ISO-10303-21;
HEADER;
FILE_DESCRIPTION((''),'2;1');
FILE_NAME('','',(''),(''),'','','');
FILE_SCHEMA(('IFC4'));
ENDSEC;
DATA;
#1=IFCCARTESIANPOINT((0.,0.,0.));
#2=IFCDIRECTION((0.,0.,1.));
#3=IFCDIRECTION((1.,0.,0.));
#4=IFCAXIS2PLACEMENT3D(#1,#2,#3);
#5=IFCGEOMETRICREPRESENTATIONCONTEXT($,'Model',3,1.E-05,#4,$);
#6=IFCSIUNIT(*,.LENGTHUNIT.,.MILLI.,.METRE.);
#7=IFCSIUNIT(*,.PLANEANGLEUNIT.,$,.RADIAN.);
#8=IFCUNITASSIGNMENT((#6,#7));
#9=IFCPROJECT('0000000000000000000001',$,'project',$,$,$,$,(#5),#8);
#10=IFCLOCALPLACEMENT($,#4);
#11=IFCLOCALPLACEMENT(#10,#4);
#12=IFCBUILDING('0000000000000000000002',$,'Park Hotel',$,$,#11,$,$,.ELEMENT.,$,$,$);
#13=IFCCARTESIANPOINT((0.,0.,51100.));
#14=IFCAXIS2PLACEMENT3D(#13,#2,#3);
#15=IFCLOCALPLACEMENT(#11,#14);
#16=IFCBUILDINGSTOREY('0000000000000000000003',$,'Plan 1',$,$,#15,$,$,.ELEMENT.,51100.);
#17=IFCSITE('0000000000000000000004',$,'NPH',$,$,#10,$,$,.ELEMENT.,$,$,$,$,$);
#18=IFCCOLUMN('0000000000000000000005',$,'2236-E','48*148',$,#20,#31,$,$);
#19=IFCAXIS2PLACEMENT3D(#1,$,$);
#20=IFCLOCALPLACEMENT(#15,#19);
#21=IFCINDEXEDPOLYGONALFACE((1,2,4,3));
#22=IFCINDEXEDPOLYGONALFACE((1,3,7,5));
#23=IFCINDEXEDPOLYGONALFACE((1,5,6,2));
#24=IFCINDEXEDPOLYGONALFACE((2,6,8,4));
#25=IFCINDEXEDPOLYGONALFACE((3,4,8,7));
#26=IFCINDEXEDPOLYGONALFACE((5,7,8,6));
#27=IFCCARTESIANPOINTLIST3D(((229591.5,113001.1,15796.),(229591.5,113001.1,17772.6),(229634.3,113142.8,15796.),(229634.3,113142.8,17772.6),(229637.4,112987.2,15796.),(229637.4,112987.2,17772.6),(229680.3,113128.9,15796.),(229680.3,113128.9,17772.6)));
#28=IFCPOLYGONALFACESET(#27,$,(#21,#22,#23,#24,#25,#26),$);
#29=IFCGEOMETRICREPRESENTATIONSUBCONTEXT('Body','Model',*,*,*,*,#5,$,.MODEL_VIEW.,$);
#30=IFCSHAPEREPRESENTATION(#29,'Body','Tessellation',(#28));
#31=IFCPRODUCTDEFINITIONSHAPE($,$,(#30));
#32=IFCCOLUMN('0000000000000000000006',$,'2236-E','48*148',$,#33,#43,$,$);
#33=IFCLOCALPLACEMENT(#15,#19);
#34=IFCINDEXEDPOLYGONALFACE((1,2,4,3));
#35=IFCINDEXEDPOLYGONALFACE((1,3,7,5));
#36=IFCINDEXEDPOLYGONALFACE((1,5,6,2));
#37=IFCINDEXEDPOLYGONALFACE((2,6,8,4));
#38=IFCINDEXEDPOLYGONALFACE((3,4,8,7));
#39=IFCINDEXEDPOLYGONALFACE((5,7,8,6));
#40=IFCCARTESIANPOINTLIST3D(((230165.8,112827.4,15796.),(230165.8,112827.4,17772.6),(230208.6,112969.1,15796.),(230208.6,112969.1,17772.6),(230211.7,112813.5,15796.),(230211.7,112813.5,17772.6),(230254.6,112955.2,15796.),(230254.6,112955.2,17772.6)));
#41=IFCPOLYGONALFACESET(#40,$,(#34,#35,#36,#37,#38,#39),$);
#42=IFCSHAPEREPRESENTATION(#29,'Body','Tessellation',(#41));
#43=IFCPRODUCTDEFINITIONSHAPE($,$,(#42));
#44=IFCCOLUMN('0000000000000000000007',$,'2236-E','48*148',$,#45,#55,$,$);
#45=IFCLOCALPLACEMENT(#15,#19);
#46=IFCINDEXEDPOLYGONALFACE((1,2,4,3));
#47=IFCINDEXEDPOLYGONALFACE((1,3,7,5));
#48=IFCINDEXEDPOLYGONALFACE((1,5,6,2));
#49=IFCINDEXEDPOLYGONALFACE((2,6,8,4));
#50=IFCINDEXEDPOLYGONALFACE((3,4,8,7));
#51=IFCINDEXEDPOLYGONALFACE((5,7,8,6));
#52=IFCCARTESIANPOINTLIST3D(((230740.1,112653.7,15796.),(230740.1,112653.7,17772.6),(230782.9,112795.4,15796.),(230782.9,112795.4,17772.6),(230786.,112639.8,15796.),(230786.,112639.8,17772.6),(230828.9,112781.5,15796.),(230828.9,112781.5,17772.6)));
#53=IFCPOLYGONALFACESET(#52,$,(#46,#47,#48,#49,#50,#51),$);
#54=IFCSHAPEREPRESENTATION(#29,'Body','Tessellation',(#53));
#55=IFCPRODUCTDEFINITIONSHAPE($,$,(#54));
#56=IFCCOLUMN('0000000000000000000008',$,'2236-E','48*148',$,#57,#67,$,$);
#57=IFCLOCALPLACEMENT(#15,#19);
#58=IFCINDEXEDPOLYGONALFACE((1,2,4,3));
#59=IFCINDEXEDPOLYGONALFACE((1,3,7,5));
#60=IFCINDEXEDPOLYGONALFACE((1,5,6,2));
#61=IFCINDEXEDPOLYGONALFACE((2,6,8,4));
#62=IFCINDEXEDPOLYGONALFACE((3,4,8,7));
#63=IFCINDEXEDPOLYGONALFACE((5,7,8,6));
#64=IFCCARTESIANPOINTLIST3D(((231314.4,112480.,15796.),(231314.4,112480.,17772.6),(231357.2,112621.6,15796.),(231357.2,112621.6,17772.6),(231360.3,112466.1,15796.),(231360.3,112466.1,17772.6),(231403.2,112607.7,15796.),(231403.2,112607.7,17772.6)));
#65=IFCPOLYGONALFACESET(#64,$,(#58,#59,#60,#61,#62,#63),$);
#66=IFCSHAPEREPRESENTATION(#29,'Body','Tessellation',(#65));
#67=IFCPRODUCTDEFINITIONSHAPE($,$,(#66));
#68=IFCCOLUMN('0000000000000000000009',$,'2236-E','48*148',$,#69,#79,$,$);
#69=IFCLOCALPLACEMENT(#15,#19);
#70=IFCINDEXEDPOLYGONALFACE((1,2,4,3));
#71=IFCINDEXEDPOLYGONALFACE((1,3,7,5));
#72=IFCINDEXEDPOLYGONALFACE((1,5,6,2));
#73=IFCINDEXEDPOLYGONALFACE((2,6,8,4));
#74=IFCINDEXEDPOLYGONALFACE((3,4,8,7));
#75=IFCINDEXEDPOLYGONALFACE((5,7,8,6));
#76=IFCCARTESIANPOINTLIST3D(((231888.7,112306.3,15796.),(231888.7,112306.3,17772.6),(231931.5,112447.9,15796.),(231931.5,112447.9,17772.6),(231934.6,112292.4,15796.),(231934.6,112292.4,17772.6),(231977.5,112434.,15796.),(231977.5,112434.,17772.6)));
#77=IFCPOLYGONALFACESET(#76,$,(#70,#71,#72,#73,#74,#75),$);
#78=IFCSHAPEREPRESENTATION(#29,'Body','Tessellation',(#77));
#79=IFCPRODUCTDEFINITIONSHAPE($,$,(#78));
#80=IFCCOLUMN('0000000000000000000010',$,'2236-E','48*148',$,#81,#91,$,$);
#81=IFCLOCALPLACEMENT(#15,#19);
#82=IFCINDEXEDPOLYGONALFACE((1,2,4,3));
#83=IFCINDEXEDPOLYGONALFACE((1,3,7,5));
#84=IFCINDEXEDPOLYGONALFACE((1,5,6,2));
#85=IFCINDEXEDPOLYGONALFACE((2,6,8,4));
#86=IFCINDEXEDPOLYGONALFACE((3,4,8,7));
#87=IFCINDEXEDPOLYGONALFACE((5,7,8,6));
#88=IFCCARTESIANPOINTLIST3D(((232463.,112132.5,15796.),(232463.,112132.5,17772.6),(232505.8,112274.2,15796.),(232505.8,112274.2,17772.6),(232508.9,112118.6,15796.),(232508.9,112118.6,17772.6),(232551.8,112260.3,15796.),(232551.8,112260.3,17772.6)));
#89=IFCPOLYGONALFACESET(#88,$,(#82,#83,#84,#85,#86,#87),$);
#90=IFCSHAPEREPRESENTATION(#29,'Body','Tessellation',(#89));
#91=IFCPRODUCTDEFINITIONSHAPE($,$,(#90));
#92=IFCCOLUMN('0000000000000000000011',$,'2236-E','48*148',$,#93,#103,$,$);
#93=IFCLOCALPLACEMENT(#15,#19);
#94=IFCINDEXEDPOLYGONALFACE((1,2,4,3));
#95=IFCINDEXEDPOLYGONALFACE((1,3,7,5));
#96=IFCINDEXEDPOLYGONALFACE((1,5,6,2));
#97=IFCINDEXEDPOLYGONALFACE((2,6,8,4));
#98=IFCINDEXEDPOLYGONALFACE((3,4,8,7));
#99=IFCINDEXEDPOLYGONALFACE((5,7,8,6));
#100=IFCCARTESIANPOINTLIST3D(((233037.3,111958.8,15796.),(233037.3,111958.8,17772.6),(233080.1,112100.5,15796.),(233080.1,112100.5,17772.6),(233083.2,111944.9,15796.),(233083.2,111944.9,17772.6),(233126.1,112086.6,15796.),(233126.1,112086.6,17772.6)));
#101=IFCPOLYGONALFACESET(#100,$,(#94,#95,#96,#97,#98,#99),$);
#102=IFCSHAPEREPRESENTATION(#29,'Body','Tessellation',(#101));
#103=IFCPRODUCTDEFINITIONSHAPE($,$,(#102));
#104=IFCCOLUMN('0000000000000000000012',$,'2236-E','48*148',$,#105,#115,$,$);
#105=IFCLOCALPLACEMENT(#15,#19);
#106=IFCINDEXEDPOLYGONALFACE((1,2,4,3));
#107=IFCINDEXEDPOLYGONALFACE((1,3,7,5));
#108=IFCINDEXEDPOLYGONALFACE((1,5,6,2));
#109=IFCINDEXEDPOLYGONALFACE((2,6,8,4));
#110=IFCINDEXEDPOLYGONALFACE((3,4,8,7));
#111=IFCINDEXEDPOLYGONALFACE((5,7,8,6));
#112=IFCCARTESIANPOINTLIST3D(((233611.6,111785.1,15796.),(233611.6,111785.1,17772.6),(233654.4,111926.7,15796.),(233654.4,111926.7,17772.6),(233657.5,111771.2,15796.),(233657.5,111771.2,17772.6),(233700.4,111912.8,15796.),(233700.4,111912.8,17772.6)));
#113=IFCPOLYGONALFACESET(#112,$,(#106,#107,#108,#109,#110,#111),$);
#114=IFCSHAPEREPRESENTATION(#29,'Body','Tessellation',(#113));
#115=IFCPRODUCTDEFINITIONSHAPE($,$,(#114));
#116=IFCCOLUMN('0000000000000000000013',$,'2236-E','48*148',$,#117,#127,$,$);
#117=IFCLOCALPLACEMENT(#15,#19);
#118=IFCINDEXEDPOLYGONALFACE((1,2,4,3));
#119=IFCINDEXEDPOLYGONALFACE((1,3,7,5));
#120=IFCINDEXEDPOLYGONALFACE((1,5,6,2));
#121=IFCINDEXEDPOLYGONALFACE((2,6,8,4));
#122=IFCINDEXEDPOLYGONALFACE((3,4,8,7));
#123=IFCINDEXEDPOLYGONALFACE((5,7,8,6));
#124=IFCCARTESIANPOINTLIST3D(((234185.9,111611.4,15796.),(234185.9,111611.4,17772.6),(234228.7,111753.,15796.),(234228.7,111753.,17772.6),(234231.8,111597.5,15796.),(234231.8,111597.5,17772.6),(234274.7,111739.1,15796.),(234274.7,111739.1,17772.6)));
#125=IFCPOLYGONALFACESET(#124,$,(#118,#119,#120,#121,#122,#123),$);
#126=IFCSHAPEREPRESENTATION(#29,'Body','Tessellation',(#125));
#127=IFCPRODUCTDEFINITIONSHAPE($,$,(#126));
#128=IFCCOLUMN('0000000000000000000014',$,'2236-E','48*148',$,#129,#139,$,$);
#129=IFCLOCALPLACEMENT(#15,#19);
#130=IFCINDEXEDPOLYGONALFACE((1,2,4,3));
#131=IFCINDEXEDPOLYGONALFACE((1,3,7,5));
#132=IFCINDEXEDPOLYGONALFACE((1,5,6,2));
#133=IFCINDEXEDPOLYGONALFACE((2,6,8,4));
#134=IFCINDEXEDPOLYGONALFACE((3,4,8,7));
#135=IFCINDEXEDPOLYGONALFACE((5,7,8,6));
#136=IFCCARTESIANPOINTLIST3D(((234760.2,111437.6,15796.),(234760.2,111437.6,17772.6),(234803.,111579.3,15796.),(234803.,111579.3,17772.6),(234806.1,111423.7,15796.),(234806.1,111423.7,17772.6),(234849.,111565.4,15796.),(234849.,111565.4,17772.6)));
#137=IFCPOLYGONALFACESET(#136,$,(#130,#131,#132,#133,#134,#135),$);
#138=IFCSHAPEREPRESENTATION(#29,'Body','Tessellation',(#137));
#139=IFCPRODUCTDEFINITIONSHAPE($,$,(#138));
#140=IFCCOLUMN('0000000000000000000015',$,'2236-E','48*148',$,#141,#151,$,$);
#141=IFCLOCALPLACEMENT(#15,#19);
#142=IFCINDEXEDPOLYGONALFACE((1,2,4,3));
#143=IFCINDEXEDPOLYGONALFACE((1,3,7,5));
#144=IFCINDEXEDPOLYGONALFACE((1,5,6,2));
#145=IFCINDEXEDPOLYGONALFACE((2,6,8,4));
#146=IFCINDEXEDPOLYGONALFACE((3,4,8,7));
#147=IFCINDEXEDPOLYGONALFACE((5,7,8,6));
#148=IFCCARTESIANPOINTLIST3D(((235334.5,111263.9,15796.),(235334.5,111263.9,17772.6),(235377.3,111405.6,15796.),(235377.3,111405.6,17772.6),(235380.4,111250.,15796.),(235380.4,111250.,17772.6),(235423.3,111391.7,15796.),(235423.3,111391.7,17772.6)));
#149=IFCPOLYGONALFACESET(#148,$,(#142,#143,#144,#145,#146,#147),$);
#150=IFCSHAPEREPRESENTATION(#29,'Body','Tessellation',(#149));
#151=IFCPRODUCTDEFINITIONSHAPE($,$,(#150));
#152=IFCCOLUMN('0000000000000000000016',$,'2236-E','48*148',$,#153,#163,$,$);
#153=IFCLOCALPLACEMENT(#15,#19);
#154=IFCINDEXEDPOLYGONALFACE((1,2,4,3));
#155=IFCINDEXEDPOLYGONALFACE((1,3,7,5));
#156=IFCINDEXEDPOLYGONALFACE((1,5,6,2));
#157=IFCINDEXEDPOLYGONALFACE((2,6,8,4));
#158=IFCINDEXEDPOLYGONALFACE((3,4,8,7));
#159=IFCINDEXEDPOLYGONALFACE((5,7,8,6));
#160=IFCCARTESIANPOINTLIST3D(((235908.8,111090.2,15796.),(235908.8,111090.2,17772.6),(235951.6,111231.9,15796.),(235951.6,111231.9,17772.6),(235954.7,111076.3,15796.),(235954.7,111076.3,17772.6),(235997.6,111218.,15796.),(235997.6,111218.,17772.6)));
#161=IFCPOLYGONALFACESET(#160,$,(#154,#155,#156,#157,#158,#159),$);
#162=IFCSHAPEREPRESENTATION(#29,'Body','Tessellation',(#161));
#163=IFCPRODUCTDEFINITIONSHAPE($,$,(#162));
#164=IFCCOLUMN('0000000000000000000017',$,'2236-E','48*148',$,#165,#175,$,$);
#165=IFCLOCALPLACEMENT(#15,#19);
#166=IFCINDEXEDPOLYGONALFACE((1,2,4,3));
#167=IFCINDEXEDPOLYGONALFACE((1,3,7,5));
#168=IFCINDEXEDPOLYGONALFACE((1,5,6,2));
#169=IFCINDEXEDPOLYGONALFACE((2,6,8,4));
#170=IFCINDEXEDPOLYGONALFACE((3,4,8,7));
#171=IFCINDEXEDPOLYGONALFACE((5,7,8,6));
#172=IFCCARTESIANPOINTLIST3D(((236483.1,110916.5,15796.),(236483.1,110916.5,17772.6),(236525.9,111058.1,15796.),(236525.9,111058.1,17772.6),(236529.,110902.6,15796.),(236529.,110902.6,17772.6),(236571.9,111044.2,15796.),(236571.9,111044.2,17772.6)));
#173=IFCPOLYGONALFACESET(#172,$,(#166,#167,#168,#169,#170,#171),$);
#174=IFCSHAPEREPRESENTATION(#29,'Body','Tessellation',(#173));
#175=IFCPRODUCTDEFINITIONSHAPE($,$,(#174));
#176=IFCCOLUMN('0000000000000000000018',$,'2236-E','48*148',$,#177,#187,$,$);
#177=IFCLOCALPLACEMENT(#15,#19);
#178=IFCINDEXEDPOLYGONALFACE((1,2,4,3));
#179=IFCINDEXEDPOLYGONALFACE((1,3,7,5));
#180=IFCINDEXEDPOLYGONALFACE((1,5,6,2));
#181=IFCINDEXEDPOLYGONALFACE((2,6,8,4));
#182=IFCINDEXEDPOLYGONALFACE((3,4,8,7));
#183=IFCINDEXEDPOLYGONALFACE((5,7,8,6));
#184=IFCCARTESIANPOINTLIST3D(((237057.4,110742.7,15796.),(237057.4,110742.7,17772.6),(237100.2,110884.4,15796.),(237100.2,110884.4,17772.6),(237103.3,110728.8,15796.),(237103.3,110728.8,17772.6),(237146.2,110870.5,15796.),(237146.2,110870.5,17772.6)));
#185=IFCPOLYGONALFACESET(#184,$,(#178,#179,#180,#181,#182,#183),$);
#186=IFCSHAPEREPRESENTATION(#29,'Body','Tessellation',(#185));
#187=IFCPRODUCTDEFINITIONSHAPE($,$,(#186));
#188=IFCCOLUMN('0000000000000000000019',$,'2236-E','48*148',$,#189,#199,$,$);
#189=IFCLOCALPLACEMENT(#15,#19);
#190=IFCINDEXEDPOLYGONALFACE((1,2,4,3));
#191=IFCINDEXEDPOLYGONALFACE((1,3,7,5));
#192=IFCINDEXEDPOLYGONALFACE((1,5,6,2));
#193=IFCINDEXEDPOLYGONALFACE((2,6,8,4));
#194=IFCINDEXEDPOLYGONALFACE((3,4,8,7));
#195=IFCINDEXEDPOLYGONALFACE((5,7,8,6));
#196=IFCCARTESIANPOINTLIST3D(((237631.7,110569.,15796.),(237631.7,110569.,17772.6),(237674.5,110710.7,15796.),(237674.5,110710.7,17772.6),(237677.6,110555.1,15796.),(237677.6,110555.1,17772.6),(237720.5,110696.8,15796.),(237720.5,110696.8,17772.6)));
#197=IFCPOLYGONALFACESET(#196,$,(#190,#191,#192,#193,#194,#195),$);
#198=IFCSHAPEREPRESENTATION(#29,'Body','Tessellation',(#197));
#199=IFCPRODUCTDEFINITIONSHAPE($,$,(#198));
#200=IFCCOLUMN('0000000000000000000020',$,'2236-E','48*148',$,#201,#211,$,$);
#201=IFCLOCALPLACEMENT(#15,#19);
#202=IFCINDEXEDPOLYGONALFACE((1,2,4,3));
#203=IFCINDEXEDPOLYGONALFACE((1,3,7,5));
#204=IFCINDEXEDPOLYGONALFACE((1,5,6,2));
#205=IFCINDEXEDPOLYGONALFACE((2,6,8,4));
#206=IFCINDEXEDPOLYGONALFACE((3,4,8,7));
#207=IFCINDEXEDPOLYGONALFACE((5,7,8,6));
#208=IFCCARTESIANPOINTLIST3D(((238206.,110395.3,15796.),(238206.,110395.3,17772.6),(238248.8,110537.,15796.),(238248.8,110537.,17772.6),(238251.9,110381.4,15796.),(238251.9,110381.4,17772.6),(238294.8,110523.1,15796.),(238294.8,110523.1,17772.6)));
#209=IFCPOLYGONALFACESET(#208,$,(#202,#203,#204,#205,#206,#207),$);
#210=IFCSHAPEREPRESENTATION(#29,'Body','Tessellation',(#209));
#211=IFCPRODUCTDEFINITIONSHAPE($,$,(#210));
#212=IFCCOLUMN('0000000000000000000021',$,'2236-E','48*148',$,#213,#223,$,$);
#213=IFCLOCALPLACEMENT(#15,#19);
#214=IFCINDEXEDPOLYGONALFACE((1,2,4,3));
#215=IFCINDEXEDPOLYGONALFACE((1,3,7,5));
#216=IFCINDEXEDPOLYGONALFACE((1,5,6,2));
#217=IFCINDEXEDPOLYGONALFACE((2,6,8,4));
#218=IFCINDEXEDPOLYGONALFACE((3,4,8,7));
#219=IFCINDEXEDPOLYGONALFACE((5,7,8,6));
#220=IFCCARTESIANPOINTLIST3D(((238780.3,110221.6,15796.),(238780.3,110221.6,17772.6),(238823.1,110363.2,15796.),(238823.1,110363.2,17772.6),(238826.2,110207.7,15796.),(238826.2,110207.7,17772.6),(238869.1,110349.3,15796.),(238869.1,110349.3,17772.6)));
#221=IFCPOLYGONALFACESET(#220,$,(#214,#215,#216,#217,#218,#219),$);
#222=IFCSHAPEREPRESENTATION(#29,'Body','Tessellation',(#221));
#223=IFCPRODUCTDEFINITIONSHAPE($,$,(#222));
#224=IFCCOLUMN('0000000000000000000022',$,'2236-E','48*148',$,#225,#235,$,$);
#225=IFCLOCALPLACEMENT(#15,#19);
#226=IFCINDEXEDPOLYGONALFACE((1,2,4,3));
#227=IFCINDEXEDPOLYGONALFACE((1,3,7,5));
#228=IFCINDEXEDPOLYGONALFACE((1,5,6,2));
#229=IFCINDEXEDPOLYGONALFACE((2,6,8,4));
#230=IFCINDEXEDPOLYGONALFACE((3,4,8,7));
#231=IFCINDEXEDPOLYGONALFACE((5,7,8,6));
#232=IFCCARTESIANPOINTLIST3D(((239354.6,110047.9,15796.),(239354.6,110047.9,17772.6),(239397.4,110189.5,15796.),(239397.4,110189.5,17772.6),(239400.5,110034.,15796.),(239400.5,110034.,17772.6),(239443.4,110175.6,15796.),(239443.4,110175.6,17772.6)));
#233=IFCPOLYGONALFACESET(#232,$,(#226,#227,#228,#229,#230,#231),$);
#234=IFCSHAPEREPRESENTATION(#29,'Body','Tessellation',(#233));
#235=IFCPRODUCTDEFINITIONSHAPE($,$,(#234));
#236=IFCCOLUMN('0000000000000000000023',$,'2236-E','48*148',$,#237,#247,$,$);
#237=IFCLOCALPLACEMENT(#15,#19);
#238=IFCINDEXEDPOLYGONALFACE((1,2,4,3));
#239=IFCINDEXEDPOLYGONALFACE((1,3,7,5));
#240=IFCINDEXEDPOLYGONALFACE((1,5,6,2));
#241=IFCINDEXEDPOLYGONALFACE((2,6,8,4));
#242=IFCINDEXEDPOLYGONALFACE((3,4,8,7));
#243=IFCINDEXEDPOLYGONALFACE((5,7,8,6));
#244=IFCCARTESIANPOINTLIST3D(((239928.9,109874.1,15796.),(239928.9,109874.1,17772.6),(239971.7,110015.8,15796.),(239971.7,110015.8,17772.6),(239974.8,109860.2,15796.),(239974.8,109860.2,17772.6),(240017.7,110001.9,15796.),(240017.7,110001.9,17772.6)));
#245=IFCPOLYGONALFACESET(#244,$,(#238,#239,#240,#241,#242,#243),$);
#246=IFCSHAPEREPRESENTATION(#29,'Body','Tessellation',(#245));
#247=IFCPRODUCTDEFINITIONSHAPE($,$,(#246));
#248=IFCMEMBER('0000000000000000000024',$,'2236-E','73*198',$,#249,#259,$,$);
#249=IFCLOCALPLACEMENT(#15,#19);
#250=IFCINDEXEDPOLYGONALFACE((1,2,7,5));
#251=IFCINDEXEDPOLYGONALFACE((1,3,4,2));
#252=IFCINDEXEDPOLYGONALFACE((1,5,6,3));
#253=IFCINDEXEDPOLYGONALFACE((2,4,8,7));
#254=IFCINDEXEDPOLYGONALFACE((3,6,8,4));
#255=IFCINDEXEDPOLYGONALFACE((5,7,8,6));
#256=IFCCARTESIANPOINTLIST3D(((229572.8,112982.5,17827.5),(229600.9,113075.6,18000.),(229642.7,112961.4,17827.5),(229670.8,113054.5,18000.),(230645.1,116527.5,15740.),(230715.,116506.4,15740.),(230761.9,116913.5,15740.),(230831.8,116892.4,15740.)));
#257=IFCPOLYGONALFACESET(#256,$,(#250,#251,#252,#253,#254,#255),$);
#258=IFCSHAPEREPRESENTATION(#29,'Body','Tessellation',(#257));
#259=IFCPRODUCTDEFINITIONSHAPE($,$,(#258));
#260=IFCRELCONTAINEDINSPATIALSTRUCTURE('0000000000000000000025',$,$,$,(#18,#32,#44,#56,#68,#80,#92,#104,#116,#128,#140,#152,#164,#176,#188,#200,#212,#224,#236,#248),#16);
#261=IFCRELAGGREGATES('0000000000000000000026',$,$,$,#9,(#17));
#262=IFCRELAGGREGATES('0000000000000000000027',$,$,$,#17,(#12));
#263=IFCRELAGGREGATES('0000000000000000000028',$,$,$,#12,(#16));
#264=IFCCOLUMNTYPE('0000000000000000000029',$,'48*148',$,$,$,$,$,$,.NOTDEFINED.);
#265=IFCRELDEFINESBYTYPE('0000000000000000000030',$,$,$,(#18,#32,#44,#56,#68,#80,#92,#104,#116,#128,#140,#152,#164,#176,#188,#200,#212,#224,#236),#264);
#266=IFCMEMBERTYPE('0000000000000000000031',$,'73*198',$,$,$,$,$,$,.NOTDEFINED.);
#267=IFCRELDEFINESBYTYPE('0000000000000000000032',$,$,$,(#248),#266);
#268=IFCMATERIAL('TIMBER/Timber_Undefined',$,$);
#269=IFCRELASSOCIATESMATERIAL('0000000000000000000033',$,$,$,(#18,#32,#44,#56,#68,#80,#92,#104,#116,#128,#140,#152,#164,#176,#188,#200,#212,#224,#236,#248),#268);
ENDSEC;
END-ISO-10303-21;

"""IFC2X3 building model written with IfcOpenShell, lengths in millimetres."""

from ifc_helpers import new_model, si_unit, frame, origin_with_axes, origin_2d_with_axis, place, context, subcontext, project, spatial, rectangle, extrude, clip, halfspace, material, type_object, element, save


model = new_model("IFC2X3")

# Units and contexts
model_context = context("Model", 3, precision=1e-05, world=origin_with_axes())
body_context = subcontext(model_context, "Body", "Model", "MODEL_VIEW")
ifc_project = project(units=[si_unit("LENGTHUNIT", "METRE", prefix="MILLI"), si_unit("PLANEANGLEUNIT", "RADIAN")], contexts=[model_context])

# Site, building, storey
site_placement = place(None, origin_with_axes())
site = spatial("IfcSite", under=ifc_project, at=site_placement, Name="NPH", CompositionType="ELEMENT")
building_placement = place(site_placement, origin_with_axes())
building = spatial("IfcBuilding", under=site, at=building_placement, Name="Park Hotel", CompositionType="ELEMENT")
storey_placement = place(building_placement, frame((0.0, 0.0, 51100.0), z_axis=(0.0, 0.0, 1.0), x_axis=(1.0, 0.0, 0.0)))
storey = spatial("IfcBuildingStorey", under=building, at=storey_placement, Name="Plan 1", CompositionType="ELEMENT", Elevation=51100.0)

# Columns
ifc_material = material(Name="TIMBER/Timber_Undefined")
column_type = type_object("IfcColumnType", Name="48*148", PredefinedType="NOTDEFINED")
for number, where, z_axis, x_axis, name in (
    (1, (229635.9, 113065.0, 17772.6), (0.0, 0.0, -1.0), (0.957167, -0.289538, 0.0), "2236-E"),
    (2, (230210.2, 112891.3, 17772.6), (0.0, 0.0, -1.0), (0.957167, -0.289538, 0.0), "2236-E"),
    (3, (230784.5, 112717.6, 17772.6), (0.0, 0.0, -1.0), (0.957167, -0.289538, 0.0), "2236-E"),
    (4, (231358.8, 112543.9, 17772.6), (0.0, 0.0, -1.0), (0.957167, -0.289538, 0.0), "2236-E"),
    (5, (231933.1, 112370.1, 17772.6), (0.0, 0.0, -1.0), (0.957167, -0.289538, 0.0), "2236-E"),
    (6, (232507.4, 112196.4, 17772.6), (0.0, 0.0, -1.0), (0.957167, -0.289538, 0.0), "2236-E"),
    (7, (233081.7, 112022.7, 17772.6), (0.0, 0.0, -1.0), (0.957167, -0.289538, 0.0), "2236-E"),
    (8, (233656.0, 111849.0, 17772.6), (0.0, 0.0, -1.0), (0.957167, -0.289538, 0.0), "2236-E"),
    (9, (234230.3, 111675.2, 17772.6), (0.0, 0.0, -1.0), (0.957167, -0.289538, 0.0), "2236-E"),
    (10, (234804.6, 111501.5, 17772.6), (0.0, 0.0, -1.0), (0.957167, -0.289538, 0.0), "2236-E"),
    (11, (235378.9, 111327.8, 17772.6), (0.0, 0.0, -1.0), (0.957167, -0.289538, 0.0), "2236-E"),
    (12, (235953.2, 111154.1, 17772.6), (0.0, 0.0, -1.0), (0.957167, -0.289538, 0.0), "2236-E"),
    (13, (236527.5, 110980.3, 17772.6), (0.0, 0.0, -1.0), (0.957167, -0.289538, 0.0), "2236-E"),
    (14, (237101.8, 110806.6, 17772.6), (0.0, 0.0, -1.0), (0.957167, -0.289538, 0.0), "2236-E"),
    (15, (237676.1, 110632.9, 17772.6), (0.0, 0.0, -1.0), (0.957167, -0.289538, 0.0), "2236-E"),
    (16, (238250.4, 110459.2, 17772.6), (0.0, 0.0, -1.0), (0.957167, -0.289538, 0.0), "2236-E"),
    (17, (238824.7, 110285.5, 17772.6), (0.0, 0.0, -1.0), (0.957167, -0.289538, 0.0), "2236-E"),
    (18, (239399.0, 110111.7, 17772.6), (0.0, 0.0, -1.0), (0.957167, -0.289538, 0.0), "2236-E"),
    (19, (239973.3, 109938.0, 17772.6), (0.0, 0.0, -1.0), (0.957167, -0.289538, 0.0), "2236-E"),
):
    element("IfcColumn", number, at=place(storey_placement, frame(where, z_axis=z_axis, x_axis=x_axis)), inside=storey, type_object=column_type, material=ifc_material, Name=name, Description="48*148", context=body_context, shape_type="SweptSolid", body=[
        extrude(rectangle(XDim=148.0, YDim=48.0, at=origin_2d_with_axis()), frame((0.0, 0.0, 1976.6), z_axis=(0.0, 0.0, -1.0), x_axis=(0.0, 1.0, 0.0)), (0.0, 0.0, 1.0), 1976.6),
    ])

# Member
member_type = type_object("IfcMemberType", Name="73*198", PredefinedType="NOTDEFINED")
for number, where, z_axis, x_axis, name in (
    (20, (229621.8, 113018.5, 17913.8), (-0.957167, 0.289538, 0.0), (0.252232, 0.833838, -0.491013), "2236-E"),
):
    element("IfcMember", number, at=place(storey_placement, frame(where, z_axis=z_axis, x_axis=x_axis)), inside=storey, type_object=member_type, material=ifc_material, Name=name, Description="73*198", context=body_context, shape_type="Clipping", body=[
        clip(extrude(rectangle(XDim=198.0, YDim=73.0, at=origin_2d_with_axis()), frame((9470.2, 0.0, 0.0), z_axis=(-1.0, 0.0, 0.0), x_axis=(0.0, -1.0, 0.0)), (0.0, 0.0, 1.0), 9470.2), halfspace(frame((4746.2, -179.9, -36.5), z_axis=(0.491013, 0.871152, 0.0), x_axis=(0.0, 0.0, 1.0)), False)),
    ])

save(model, "model.ifc")
